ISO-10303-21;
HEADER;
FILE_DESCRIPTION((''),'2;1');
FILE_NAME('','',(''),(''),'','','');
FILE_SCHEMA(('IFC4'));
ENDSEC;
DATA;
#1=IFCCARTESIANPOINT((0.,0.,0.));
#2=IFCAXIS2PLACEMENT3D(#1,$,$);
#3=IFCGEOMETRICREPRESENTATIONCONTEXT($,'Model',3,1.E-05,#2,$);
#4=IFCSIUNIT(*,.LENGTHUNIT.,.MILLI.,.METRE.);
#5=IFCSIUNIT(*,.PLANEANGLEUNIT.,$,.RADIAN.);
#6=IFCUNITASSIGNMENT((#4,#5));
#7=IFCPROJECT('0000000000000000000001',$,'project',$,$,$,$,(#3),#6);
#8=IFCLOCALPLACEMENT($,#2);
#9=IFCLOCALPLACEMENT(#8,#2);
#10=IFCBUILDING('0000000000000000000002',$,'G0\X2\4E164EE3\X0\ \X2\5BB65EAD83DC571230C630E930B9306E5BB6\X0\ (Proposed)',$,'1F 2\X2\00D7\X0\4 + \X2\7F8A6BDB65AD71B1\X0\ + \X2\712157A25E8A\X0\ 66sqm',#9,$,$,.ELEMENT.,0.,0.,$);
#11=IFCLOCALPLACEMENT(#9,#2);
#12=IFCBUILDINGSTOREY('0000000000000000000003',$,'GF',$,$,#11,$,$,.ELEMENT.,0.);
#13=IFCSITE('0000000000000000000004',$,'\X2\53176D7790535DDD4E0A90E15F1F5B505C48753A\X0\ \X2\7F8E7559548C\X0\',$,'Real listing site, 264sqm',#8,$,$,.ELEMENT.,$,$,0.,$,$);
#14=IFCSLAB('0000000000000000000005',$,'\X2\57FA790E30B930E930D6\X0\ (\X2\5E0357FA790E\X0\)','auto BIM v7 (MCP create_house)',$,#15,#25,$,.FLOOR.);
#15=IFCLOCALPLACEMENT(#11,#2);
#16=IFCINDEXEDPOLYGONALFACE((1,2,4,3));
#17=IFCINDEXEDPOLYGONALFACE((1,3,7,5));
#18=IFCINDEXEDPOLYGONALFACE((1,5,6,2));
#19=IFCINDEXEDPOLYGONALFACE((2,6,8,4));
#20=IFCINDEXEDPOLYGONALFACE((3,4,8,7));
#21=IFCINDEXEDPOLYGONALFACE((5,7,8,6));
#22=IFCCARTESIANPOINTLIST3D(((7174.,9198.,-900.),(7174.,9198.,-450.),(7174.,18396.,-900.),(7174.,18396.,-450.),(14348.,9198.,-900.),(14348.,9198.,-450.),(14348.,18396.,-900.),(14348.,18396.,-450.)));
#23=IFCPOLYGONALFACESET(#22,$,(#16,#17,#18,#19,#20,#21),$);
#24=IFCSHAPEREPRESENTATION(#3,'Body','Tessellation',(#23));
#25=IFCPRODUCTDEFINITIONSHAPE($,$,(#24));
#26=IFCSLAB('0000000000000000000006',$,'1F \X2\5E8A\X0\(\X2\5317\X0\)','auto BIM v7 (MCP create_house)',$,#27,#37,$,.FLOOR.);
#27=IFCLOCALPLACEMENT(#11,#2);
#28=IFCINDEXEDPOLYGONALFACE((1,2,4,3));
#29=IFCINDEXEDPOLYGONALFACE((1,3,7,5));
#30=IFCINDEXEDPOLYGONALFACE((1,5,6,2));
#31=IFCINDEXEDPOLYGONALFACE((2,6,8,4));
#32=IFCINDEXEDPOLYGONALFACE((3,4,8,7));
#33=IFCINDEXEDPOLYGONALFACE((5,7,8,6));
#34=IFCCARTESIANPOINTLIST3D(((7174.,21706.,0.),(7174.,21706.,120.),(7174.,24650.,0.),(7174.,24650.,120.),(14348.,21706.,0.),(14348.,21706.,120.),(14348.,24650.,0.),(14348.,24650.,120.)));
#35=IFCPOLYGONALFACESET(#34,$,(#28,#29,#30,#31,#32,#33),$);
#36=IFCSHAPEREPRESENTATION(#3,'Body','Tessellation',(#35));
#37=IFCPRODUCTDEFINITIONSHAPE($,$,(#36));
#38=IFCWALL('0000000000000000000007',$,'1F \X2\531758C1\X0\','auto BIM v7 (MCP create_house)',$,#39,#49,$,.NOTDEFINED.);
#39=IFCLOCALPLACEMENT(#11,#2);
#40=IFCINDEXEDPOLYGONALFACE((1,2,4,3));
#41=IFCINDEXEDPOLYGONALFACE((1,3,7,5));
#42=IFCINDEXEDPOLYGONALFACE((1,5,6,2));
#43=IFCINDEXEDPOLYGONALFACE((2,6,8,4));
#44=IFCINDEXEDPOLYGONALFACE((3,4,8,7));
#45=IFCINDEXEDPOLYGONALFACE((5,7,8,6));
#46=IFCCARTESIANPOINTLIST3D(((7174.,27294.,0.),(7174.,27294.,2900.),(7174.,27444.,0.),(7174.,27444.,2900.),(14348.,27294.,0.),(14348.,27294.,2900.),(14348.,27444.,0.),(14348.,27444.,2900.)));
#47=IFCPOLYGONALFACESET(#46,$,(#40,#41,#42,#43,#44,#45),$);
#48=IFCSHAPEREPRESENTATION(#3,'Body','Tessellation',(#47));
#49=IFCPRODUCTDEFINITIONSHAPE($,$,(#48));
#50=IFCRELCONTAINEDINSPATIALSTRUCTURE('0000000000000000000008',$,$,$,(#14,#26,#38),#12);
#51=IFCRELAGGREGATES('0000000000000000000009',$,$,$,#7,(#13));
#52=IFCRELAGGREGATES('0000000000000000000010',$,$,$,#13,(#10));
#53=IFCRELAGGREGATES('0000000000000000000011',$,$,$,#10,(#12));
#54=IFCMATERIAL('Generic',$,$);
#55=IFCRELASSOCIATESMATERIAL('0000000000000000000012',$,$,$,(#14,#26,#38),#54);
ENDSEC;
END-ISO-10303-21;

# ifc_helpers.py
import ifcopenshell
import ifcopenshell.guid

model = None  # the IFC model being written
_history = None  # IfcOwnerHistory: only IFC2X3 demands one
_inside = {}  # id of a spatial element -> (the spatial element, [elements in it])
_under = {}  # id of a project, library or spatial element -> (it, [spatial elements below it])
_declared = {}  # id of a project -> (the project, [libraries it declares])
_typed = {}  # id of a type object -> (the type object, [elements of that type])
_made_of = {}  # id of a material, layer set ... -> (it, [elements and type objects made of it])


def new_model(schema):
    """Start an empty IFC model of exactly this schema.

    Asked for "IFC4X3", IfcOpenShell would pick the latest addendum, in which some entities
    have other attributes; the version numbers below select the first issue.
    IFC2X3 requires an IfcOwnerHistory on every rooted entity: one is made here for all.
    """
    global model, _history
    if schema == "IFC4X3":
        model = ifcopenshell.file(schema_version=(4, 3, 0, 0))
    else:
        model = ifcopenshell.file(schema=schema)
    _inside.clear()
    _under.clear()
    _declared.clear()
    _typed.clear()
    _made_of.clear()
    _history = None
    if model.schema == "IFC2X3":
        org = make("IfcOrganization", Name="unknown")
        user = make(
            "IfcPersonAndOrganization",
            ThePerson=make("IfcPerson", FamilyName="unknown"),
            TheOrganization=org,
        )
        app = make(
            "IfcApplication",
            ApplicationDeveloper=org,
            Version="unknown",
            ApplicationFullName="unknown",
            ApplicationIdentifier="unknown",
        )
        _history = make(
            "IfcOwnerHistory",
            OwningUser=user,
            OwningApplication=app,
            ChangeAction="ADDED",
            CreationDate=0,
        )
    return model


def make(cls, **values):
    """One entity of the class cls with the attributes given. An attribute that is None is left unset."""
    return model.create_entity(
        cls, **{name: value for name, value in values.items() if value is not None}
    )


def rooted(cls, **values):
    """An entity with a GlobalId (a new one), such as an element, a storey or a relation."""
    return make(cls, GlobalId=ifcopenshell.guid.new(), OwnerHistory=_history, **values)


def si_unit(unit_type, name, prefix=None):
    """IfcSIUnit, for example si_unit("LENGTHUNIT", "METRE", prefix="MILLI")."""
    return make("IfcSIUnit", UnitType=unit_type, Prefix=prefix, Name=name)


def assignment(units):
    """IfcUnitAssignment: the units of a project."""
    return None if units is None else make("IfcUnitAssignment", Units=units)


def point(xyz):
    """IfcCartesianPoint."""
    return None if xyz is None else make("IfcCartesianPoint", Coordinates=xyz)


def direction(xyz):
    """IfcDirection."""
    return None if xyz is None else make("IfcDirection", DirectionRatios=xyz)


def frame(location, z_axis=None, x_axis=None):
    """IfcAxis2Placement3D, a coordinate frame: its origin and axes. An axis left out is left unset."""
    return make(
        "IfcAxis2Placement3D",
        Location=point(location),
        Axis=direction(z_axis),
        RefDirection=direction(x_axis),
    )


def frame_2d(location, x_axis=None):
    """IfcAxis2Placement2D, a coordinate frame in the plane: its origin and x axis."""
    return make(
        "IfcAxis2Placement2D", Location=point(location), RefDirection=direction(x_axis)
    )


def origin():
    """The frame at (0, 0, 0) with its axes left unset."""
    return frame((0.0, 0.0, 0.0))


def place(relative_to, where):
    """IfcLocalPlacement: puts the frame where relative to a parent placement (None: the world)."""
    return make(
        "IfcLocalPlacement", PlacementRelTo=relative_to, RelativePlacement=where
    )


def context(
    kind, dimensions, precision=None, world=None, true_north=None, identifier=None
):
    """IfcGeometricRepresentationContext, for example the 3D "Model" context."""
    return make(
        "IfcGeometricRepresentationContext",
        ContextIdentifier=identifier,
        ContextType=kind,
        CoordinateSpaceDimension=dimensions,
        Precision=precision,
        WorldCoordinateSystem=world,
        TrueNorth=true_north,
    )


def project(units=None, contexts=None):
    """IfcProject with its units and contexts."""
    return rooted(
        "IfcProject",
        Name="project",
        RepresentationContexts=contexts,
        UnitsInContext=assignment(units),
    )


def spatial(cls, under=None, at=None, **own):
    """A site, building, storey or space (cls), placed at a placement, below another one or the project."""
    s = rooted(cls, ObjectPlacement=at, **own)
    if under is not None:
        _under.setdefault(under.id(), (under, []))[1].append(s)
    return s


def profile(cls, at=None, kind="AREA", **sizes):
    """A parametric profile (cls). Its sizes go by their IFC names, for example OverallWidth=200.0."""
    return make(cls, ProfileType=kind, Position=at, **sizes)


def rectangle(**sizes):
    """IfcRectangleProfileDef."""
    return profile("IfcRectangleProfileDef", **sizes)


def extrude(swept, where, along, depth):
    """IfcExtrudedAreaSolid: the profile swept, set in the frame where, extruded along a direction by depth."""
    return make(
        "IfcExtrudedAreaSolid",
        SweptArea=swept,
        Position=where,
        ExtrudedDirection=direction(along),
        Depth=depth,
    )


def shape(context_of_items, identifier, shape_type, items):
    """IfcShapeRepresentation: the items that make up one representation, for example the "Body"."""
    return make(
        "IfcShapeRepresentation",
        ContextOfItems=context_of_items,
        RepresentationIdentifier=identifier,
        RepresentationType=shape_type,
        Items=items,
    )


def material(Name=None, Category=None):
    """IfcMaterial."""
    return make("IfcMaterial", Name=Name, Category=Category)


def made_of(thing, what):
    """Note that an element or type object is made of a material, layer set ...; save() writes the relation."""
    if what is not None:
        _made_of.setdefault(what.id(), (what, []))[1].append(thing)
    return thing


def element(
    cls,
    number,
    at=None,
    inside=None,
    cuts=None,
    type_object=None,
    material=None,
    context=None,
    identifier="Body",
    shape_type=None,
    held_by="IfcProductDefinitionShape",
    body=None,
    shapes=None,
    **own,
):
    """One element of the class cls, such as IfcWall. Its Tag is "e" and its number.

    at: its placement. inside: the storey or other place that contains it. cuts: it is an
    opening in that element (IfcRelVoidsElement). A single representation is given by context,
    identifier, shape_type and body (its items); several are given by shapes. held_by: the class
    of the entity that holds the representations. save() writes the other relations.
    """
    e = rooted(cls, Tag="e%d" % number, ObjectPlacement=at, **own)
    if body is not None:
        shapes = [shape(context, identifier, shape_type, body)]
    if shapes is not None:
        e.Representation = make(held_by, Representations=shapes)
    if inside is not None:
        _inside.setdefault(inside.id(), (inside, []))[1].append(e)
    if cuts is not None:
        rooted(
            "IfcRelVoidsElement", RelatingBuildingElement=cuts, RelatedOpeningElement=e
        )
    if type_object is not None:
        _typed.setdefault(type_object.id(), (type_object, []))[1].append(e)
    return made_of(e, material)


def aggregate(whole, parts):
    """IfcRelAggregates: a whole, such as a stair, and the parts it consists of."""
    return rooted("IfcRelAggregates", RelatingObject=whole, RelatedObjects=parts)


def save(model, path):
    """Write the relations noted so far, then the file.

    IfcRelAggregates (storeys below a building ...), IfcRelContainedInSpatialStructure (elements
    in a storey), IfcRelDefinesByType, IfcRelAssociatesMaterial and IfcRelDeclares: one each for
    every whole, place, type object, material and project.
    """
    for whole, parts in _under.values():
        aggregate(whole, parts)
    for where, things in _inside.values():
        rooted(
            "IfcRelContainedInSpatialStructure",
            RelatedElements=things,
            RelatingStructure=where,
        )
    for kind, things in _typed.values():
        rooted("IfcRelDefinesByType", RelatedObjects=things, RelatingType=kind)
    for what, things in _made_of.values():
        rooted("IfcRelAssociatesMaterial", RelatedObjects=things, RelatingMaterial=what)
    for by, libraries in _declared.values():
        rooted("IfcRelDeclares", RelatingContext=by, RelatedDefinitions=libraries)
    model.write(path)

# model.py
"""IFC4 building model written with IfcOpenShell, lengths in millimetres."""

from ifc_helpers import new_model, si_unit, frame, frame_2d, origin, place, context, project, spatial, rectangle, extrude, material, element, save


model = new_model("IFC4")

# Units and contexts
model_context = context("Model", 3, precision=1e-05, world=origin())
ifc_project = project(units=[si_unit("LENGTHUNIT", "METRE", prefix="MILLI"), si_unit("PLANEANGLEUNIT", "RADIAN")], contexts=[model_context])

# Site, building, storey
site_placement = place(None, origin())
site = spatial("IfcSite", under=ifc_project, at=site_placement, Name="北海道川上郡弟子屈町 美留和", ObjectType="Real listing site, 264sqm", CompositionType="ELEMENT", RefElevation=0.0)
building_placement = place(site_placement, origin())
building = spatial("IfcBuilding", under=site, at=building_placement, Name="G0世代 家庭菜園テラスの家 (Proposed)", ObjectType="1F 2×4 + 羊毛断熱 + 無垢床 66sqm", CompositionType="ELEMENT", ElevationOfRefHeight=0.0, ElevationOfTerrain=0.0)
storey_placement = place(building_placement, origin())
storey = spatial("IfcBuildingStorey", under=building, at=storey_placement, Name="GF", CompositionType="ELEMENT", Elevation=0.0)

# Slabs
ifc_material = material(Name="Generic")
slab_1_placement = place(storey_placement, frame((3587.0, 4599.0, -450.0)))
element("IfcSlab", 1, at=slab_1_placement, inside=storey, material=ifc_material, Name="基礎スラブ (布基礎)", Description="auto BIM v7 (MCP create_house)", PredefinedType="FLOOR", context=model_context, shape_type="SweptSolid", body=[
    extrude(rectangle(XDim=7174.0, YDim=9198.0, at=frame_2d((3587.0, 4599.0))), frame((3587.0, 4599.0, -450.0)), (0.0, 0.0, 1.0), 450.0),
])
slab_2_placement = place(storey_placement, frame((3587.0, 10853.0, 0.0)))
element("IfcSlab", 2, at=slab_2_placement, inside=storey, material=ifc_material, Name="1F 床(北)", Description="auto BIM v7 (MCP create_house)", PredefinedType="FLOOR", context=model_context, shape_type="SweptSolid", body=[
    extrude(rectangle(XDim=7174.0, YDim=2944.0, at=frame_2d((3587.0, 1472.0))), frame((3587.0, 10853.0, 0.0)), (0.0, 0.0, 1.0), 120.0),
])

# Wall
wall_1_placement = place(storey_placement, frame((3587.0, 13647.0, 0.0)))
element("IfcWall", 3, at=wall_1_placement, inside=storey, material=ifc_material, Name="1F 北壁", Description="auto BIM v7 (MCP create_house)", PredefinedType="NOTDEFINED", context=model_context, shape_type="SweptSolid", body=[
    extrude(rectangle(XDim=7174.0, YDim=150.0, at=frame_2d((3587.0, 75.0))), frame((3587.0, 13647.0, 0.0)), (0.0, 0.0, 1.0), 2900.0),
])

save(model, "model.ifc")
